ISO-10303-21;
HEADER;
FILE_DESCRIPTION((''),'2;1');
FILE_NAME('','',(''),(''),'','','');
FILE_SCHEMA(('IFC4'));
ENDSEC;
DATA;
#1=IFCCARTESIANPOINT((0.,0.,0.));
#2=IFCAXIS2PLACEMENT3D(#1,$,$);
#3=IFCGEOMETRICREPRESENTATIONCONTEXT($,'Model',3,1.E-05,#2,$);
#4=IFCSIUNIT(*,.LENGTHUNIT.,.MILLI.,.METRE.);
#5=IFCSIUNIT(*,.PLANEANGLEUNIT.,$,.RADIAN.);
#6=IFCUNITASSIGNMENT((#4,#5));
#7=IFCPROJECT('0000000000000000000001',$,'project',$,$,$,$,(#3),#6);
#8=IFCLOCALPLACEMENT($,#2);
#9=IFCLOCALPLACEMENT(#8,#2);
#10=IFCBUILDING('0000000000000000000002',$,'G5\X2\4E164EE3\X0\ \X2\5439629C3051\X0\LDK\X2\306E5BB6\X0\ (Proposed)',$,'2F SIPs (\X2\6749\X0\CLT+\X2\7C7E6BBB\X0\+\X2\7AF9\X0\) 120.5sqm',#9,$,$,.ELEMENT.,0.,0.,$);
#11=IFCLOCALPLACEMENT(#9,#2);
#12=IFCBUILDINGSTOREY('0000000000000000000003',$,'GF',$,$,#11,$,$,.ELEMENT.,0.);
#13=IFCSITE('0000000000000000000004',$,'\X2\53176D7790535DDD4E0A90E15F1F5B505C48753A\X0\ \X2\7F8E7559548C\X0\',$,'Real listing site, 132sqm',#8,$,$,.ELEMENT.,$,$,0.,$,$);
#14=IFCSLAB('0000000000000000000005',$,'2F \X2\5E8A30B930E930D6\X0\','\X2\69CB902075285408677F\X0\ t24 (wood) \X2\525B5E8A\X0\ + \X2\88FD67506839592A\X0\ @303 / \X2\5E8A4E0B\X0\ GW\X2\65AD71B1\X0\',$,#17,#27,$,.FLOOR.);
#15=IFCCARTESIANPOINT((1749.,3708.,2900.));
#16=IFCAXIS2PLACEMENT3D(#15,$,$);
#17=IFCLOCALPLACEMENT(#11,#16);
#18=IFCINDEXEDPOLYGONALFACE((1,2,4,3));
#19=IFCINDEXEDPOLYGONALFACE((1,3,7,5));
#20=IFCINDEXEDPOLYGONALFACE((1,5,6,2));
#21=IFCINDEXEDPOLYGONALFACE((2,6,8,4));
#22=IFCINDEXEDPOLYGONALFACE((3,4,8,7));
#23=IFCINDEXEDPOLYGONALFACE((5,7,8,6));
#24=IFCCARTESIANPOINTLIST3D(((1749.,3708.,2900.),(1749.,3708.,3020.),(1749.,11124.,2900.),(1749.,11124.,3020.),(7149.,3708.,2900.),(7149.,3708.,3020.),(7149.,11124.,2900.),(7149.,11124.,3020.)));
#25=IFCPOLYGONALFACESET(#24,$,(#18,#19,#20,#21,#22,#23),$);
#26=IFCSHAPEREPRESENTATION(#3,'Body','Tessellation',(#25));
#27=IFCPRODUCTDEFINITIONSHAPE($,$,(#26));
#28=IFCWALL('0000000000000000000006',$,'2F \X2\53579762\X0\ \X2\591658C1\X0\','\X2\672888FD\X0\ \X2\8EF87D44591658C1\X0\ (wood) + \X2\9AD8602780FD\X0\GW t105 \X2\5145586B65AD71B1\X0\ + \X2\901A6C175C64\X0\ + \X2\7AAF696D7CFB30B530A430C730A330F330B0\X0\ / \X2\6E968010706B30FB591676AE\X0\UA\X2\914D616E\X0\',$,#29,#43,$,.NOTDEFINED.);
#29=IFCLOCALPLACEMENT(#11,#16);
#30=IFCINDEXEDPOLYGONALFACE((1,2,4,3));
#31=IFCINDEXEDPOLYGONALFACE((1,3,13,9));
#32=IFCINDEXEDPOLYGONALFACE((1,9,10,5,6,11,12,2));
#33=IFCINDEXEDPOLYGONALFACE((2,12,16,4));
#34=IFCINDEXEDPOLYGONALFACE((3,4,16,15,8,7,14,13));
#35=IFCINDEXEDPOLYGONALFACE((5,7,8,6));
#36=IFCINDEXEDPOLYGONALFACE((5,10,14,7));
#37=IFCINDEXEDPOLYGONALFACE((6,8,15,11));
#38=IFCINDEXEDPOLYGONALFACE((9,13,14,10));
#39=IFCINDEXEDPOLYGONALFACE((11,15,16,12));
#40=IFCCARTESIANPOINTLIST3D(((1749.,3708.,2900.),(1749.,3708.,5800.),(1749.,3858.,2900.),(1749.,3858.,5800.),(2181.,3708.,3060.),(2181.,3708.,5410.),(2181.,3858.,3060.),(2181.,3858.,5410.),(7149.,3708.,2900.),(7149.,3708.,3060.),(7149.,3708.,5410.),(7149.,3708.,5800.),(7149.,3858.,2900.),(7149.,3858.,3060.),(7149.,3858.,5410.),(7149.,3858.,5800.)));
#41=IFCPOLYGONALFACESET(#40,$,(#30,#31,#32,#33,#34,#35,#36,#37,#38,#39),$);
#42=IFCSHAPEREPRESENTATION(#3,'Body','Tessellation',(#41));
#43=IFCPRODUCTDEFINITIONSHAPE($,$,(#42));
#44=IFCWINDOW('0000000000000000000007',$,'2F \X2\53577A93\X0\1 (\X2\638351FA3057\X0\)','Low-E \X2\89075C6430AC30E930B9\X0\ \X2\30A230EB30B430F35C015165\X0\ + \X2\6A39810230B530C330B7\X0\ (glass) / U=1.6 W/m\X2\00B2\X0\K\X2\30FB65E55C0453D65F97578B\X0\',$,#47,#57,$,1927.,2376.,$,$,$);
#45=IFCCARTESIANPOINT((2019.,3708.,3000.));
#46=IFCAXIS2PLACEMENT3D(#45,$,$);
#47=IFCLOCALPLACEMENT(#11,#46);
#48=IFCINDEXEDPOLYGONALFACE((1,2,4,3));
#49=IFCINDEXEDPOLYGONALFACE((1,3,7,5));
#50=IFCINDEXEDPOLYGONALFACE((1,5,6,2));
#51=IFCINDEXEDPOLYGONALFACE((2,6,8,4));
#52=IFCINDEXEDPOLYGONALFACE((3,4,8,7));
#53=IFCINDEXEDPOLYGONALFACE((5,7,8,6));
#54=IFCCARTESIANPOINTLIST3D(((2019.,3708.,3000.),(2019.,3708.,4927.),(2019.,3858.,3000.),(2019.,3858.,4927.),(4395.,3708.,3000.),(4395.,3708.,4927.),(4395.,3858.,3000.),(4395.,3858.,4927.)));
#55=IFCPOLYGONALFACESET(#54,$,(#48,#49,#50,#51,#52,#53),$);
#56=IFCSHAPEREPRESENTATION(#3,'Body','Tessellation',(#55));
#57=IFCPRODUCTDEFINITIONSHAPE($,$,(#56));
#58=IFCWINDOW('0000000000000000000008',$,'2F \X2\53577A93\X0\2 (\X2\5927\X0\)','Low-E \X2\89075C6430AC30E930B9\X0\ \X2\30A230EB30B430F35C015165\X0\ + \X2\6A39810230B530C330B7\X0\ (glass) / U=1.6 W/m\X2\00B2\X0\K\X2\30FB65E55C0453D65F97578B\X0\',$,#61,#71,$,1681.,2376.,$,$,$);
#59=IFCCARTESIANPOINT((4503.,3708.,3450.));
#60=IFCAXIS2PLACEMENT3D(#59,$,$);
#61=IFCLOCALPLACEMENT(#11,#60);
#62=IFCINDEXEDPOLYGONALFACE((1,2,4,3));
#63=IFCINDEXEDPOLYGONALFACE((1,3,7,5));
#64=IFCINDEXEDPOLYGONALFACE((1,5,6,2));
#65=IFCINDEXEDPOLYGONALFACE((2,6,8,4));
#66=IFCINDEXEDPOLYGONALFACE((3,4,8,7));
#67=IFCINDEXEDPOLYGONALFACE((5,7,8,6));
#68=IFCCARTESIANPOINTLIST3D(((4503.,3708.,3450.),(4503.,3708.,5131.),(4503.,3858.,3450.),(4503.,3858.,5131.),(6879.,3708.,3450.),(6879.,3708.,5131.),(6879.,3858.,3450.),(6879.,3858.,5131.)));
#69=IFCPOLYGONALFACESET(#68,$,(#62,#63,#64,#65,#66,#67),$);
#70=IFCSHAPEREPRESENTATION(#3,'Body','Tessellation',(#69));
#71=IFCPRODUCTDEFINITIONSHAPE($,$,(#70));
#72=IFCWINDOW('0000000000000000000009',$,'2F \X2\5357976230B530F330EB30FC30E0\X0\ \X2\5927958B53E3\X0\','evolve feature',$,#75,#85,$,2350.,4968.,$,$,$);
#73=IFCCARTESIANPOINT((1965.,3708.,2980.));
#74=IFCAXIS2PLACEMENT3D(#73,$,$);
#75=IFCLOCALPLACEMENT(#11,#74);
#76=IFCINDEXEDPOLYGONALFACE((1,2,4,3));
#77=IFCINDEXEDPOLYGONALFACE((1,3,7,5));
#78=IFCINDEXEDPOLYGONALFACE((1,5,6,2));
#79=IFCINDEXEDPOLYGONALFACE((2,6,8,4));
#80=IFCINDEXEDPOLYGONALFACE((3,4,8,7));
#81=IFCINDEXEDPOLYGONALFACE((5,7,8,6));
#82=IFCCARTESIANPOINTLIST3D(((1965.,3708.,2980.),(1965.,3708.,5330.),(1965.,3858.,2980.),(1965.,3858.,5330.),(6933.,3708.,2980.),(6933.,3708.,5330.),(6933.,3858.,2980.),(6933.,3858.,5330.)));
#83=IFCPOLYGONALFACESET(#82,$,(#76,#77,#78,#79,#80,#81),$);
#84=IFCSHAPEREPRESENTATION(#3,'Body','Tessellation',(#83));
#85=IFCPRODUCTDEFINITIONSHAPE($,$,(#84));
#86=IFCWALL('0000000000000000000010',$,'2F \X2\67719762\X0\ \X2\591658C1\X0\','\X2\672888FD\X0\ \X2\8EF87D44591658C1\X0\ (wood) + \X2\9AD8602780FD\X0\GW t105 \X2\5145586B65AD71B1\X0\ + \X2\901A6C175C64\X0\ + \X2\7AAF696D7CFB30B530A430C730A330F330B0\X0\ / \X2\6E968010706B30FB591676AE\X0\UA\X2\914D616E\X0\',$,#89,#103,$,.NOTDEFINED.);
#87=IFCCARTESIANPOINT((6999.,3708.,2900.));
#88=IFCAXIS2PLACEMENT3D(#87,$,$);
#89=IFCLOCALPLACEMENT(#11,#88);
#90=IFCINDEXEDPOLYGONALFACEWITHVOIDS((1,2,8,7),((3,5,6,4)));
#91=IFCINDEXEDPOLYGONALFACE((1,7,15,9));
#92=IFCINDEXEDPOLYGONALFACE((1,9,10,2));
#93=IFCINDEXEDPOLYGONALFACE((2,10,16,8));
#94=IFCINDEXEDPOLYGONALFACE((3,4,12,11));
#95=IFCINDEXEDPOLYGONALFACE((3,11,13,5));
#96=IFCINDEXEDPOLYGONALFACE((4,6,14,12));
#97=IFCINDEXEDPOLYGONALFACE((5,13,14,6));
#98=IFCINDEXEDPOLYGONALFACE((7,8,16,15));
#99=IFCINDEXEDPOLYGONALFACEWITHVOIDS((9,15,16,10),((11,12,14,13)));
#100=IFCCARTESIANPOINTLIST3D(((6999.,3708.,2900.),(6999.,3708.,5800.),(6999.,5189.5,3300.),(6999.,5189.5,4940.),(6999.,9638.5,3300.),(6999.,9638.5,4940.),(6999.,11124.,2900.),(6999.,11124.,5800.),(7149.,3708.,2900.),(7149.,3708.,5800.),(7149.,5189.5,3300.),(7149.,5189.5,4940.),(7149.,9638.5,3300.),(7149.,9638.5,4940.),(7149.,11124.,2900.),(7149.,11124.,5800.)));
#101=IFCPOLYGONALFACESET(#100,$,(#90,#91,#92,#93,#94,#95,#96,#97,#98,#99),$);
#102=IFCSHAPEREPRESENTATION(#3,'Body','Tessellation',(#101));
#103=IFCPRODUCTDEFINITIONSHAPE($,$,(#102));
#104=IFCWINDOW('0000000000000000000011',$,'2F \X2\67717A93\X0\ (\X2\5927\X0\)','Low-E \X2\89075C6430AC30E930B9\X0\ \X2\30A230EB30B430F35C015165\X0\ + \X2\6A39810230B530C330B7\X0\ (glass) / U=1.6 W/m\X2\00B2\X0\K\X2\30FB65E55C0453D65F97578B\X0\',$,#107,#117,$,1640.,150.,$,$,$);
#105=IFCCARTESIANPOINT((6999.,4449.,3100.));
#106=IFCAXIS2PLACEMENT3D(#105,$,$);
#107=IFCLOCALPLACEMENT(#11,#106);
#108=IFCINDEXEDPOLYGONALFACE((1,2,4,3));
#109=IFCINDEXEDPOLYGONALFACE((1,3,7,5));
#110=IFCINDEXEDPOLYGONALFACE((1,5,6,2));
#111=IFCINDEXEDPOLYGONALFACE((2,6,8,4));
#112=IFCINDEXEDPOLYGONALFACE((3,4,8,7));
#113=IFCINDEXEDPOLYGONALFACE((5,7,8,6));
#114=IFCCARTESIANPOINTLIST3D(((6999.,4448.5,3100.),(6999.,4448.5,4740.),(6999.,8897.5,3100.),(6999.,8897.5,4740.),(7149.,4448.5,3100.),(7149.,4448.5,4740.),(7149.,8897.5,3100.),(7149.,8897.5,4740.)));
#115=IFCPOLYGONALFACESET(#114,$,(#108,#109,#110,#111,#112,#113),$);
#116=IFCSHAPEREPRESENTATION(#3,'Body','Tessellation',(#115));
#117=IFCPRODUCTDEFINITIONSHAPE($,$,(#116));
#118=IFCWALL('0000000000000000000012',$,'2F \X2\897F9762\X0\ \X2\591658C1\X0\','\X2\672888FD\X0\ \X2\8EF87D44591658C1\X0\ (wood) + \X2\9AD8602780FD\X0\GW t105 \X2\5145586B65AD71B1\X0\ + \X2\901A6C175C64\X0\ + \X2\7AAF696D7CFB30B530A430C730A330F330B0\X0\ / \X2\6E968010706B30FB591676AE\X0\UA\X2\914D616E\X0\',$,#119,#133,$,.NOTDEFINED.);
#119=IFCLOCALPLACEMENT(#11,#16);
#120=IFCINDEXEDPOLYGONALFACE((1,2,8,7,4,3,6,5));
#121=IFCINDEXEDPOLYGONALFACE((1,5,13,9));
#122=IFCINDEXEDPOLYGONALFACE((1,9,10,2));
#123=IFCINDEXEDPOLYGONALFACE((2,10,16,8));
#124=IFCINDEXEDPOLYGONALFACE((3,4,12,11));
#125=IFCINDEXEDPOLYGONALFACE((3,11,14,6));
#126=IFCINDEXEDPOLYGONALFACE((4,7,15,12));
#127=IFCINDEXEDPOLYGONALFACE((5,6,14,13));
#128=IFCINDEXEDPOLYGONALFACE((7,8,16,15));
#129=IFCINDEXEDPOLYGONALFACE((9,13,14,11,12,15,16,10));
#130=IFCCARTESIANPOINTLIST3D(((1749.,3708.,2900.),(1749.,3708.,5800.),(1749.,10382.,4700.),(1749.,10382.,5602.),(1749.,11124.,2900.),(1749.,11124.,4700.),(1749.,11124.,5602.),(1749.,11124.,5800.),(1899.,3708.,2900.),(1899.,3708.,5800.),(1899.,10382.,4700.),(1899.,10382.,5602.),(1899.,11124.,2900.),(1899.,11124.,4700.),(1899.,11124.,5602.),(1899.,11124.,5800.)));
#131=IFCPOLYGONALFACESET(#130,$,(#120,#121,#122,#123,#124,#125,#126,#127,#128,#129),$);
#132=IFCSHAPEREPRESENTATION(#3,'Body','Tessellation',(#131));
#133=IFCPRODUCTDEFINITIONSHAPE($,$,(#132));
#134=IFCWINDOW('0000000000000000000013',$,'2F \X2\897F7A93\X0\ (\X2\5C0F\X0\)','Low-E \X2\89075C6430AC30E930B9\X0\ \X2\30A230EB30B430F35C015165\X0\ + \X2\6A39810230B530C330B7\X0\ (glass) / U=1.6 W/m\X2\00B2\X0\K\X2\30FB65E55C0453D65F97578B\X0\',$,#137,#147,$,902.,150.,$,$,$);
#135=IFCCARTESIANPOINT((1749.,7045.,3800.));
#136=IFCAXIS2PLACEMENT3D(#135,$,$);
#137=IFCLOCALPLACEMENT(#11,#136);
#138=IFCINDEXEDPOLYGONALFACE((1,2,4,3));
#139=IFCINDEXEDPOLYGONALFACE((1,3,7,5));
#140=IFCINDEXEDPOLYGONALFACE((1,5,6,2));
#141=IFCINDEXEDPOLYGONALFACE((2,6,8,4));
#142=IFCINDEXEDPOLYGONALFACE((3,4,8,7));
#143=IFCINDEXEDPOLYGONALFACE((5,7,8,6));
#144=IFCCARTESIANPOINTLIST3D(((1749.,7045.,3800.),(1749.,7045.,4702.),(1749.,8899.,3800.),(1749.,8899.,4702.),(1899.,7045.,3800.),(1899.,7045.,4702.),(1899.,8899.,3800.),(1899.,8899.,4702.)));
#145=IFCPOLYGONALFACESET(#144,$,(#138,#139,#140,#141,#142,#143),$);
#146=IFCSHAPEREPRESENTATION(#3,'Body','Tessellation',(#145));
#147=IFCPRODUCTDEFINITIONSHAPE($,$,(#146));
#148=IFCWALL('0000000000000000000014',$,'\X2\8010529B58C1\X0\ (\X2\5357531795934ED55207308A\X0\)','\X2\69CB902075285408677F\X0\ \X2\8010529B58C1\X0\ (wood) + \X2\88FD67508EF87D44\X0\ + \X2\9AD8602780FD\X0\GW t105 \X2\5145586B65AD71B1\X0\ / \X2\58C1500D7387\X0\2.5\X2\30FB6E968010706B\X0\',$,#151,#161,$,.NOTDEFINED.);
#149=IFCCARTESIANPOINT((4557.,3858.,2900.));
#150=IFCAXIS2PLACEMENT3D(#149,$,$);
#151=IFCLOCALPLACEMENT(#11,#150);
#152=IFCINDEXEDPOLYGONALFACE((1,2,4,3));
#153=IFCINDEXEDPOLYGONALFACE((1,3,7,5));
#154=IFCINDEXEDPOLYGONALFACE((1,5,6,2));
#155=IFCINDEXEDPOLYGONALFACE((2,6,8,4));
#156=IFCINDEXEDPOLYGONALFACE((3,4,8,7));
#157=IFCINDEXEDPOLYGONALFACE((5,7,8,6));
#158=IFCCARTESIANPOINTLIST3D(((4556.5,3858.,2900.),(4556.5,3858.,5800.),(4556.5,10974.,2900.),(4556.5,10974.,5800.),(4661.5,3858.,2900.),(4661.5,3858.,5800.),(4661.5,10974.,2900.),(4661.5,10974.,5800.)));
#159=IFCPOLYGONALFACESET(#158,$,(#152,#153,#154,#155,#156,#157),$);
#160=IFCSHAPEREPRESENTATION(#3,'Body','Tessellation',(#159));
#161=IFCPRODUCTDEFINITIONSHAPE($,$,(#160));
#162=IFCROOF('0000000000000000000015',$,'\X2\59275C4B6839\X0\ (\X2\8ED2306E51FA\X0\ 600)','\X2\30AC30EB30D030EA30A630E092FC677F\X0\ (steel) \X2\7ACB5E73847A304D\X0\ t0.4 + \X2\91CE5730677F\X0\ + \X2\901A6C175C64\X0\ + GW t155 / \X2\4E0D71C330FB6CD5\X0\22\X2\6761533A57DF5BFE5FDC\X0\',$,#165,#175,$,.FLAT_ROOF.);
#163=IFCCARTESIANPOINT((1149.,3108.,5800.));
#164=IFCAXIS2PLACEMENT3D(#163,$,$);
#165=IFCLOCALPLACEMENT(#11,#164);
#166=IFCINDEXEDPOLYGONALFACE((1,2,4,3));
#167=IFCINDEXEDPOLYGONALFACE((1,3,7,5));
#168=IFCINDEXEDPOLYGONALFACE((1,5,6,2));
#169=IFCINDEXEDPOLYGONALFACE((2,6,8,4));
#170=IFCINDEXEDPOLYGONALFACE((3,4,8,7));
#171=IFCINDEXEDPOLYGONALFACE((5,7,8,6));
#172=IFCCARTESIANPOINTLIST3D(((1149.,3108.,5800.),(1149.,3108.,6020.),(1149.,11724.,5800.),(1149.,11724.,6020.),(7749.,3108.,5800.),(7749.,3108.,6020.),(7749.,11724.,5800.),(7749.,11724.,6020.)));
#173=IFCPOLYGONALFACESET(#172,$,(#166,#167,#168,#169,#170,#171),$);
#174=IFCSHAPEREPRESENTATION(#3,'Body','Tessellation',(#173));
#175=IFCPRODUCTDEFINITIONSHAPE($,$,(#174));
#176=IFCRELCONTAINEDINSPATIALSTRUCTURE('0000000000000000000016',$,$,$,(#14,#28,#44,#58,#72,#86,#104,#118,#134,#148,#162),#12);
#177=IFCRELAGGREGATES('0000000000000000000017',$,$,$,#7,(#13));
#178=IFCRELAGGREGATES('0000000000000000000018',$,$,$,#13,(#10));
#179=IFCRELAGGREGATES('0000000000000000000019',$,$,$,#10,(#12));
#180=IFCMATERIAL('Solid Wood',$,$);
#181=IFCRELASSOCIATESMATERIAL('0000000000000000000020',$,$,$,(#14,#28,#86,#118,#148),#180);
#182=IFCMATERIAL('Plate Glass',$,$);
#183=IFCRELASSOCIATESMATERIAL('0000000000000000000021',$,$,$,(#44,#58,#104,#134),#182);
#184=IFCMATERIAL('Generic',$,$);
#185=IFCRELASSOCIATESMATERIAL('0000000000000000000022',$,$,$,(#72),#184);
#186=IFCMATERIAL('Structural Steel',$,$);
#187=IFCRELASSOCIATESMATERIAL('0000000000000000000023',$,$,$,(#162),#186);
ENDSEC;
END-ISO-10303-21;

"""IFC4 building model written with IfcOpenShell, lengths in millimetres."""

from ifc_helpers import new_model, si_unit, frame, frame_2d, origin, place, context, project, spatial, rectangle, extrude, material, element, fill, save


model = new_model("IFC4")

# Units and contexts
model_context = context("Model", 3, precision=1e-05, world=origin())
ifc_project = project(units=[si_unit("LENGTHUNIT", "METRE", prefix="MILLI"), si_unit("PLANEANGLEUNIT", "RADIAN")], contexts=[model_context])

# Site, building, storey
site_placement = place(None, origin())
site = spatial("IfcSite", under=ifc_project, at=site_placement, Name="北海道川上郡弟子屈町 美留和", ObjectType="Real listing site, 132sqm", CompositionType="ELEMENT", RefElevation=0.0)
building_placement = place(site_placement, origin())
building = spatial("IfcBuilding", under=site, at=building_placement, Name="G5世代 吹抜けLDKの家 (Proposed)", ObjectType="2F SIPs (杉CLT+籾殻+竹) 120.5sqm", CompositionType="ELEMENT", ElevationOfRefHeight=0.0, ElevationOfTerrain=0.0)
storey_placement = place(building_placement, origin())
storey = spatial("IfcBuildingStorey", under=building, at=storey_placement, Name="GF", CompositionType="ELEMENT", Elevation=0.0)

# Slab
ifc_material_1 = material(Name="Solid Wood")
slab_placement = place(storey_placement, frame((1749.0, 3708.0, 2900.0)))
element("IfcSlab", 1, at=slab_placement, inside=storey, material=ifc_material_1, Name="2F 床スラブ", Description="構造用合板 t24 (wood) 剛床 + 製材根太 @303 / 床下 GW断熱", PredefinedType="FLOOR", context=model_context, shape_type="SweptSolid", body=[
    extrude(rectangle(XDim=5400.0, YDim=7416.0, at=frame_2d((2700.0, 3708.0))), frame((1749.0, 3708.0, 2900.0)), (0.0, 0.0, 1.0), 120.0),
])

# Wall, openings, windows
wall_1_placement = place(storey_placement, frame((1749.0, 3708.0, 2900.0)))
wall_1 = element("IfcWall", 2, at=wall_1_placement, inside=storey, material=ifc_material_1, Name="2F 南面 外壁", Description="木製 軸組外壁 (wood) + 高性能GW t105 充填断熱 + 通気層 + 窯業系サイディング / 準耐火・外皮UA配慮", PredefinedType="NOTDEFINED", context=model_context, shape_type="SweptSolid", body=[
    extrude(rectangle(XDim=5400.0, YDim=150.0, at=frame_2d((2700.0, 75.0))), frame((1749.0, 3708.0, 2900.0)), (0.0, 0.0, 1.0), 2900.0),
])
opening_1_placement = place(storey_placement, frame((2019.0, 3708.0, 3000.0)))
opening_1 = element("IfcOpeningElement", 3, at=opening_1_placement, cuts=wall_1, PredefinedType="NOTDEFINED", context=model_context, shape_type="SweptSolid", body=[
    extrude(rectangle(XDim=2376.0, YDim=150.0, at=frame_2d((1188.0, 75.0))), frame((2019.0, 3708.0, 3000.0)), (0.0, 0.0, 1.0), 1927.0),
])
opening_2_placement = place(storey_placement, frame((4503.0, 3708.0, 3450.0)))
opening_2 = element("IfcOpeningElement", 4, at=opening_2_placement, cuts=wall_1, PredefinedType="NOTDEFINED", context=model_context, shape_type="SweptSolid", body=[
    extrude(rectangle(XDim=2376.0, YDim=150.0, at=frame_2d((1188.0, 75.0))), frame((4503.0, 3708.0, 3450.0)), (0.0, 0.0, 1.0), 1681.0),
])
opening_3_placement = place(storey_placement, frame((1965.0, 3708.0, 2980.0)))
opening_3 = element("IfcOpeningElement", 5, at=opening_3_placement, cuts=wall_1, PredefinedType="NOTDEFINED", context=model_context, shape_type="SweptSolid", body=[
    extrude(rectangle(XDim=4968.0, YDim=150.0, at=frame_2d((2484.0, 75.0))), frame((1965.0, 3708.0, 2980.0)), (0.0, 0.0, 1.0), 2350.0),
])
ifc_material_2 = material(Name="Plate Glass")
window_1_placement = place(storey_placement, frame((2019.0, 3708.0, 3000.0)))
window_1 = element("IfcWindow", 6, at=window_1_placement, inside=storey, material=ifc_material_2, Name="2F 南窓1 (掃出し)", Description="Low-E 複層ガラス アルゴン封入 + 樹脂サッシ (glass) / U=1.6 W/m²K・日射取得型", OverallHeight=1927.0, OverallWidth=2376.0, context=model_context, shape_type="SweptSolid", body=[
    extrude(rectangle(XDim=2376.0, YDim=150.0, at=frame_2d((1188.0, 75.0))), frame((2019.0, 3708.0, 3000.0)), (0.0, 0.0, 1.0), 1927.0),
])
fill(opening_1, window_1)
window_2_placement = place(storey_placement, frame((4503.0, 3708.0, 3450.0)))
window_2 = element("IfcWindow", 7, at=window_2_placement, inside=storey, material=ifc_material_2, Name="2F 南窓2 (大)", Description="Low-E 複層ガラス アルゴン封入 + 樹脂サッシ (glass) / U=1.6 W/m²K・日射取得型", OverallHeight=1681.0, OverallWidth=2376.0, context=model_context, shape_type="SweptSolid", body=[
    extrude(rectangle(XDim=2376.0, YDim=150.0, at=frame_2d((1188.0, 75.0))), frame((4503.0, 3708.0, 3450.0)), (0.0, 0.0, 1.0), 1681.0),
])
fill(opening_2, window_2)
ifc_material_3 = material(Name="Generic")
window_3_placement = place(storey_placement, frame((1965.0, 3708.0, 2980.0)))
window_3 = element("IfcWindow", 8, at=window_3_placement, inside=storey, material=ifc_material_3, Name="2F 南面サンルーム 大開口", Description="evolve feature", OverallHeight=2350.0, OverallWidth=4968.0, context=model_context, shape_type="SweptSolid", body=[
    extrude(rectangle(XDim=4968.0, YDim=150.0, at=frame_2d((2484.0, 75.0))), frame((1965.0, 3708.0, 2980.0)), (0.0, 0.0, 1.0), 2350.0),
])
fill(opening_3, window_3)

# Walls, openings, windows
wall_2_placement = place(storey_placement, frame((6999.0, 3708.0, 2900.0)))
wall_2 = element("IfcWall", 9, at=wall_2_placement, inside=storey, material=ifc_material_1, Name="2F 東面 外壁", Description="木製 軸組外壁 (wood) + 高性能GW t105 充填断熱 + 通気層 + 窯業系サイディング / 準耐火・外皮UA配慮", PredefinedType="NOTDEFINED", context=model_context, shape_type="SweptSolid", body=[
    extrude(rectangle(XDim=150.0, YDim=7416.0, at=frame_2d((75.0, 3708.0))), frame((6999.0, 3708.0, 2900.0)), (0.0, 0.0, 1.0), 2900.0),
])
opening_4_placement = place(storey_placement, frame((6999.0, 4449.0, 3100.0)))
opening_4 = element("IfcOpeningElement", 10, at=opening_4_placement, cuts=wall_2, PredefinedType="NOTDEFINED", context=model_context, shape_type="SweptSolid", body=[
    extrude(rectangle(XDim=150.0, YDim=4449.0, at=frame_2d((75.0, 2224.0))), frame((6999.0, 4449.0, 3100.0)), (0.0, 0.0, 1.0), 1640.0),
])
window_4_placement = place(storey_placement, frame((6999.0, 4449.0, 3100.0)))
window_4 = element("IfcWindow", 11, at=window_4_placement, inside=storey, material=ifc_material_2, Name="2F 東窓 (大)", Description="Low-E 複層ガラス アルゴン封入 + 樹脂サッシ (glass) / U=1.6 W/m²K・日射取得型", OverallHeight=1640.0, OverallWidth=150.0, context=model_context, shape_type="SweptSolid", body=[
    extrude(rectangle(XDim=150.0, YDim=4449.0, at=frame_2d((75.0, 2224.0))), frame((6999.0, 4449.0, 3100.0)), (0.0, 0.0, 1.0), 1640.0),
])
fill(opening_4, window_4)
wall_3_placement = place(storey_placement, frame((1749.0, 3708.0, 2900.0)))
wall_3 = element("IfcWall", 12, at=wall_3_placement, inside=storey, material=ifc_material_1, Name="2F 西面 外壁", Description="木製 軸組外壁 (wood) + 高性能GW t105 充填断熱 + 通気層 + 窯業系サイディング / 準耐火・外皮UA配慮", PredefinedType="NOTDEFINED", context=model_context, shape_type="SweptSolid", body=[
    extrude(rectangle(XDim=150.0, YDim=7416.0, at=frame_2d((75.0, 3708.0))), frame((1749.0, 3708.0, 2900.0)), (0.0, 0.0, 1.0), 2900.0),
])
opening_5_placement = place(storey_placement, frame((1749.0, 7045.0, 3800.0)))
opening_5 = element("IfcOpeningElement", 13, at=opening_5_placement, cuts=wall_3, PredefinedType="NOTDEFINED", context=model_context, shape_type="SweptSolid", body=[
    extrude(rectangle(XDim=150.0, YDim=1854.0, at=frame_2d((75.0, 927.0))), frame((1749.0, 7045.0, 3800.0)), (0.0, 0.0, 1.0), 902.0),
])
window_5_placement = place(storey_placement, frame((1749.0, 7045.0, 3800.0)))
window_5 = element("IfcWindow", 14, at=window_5_placement, inside=storey, material=ifc_material_2, Name="2F 西窓 (小)", Description="Low-E 複層ガラス アルゴン封入 + 樹脂サッシ (glass) / U=1.6 W/m²K・日射取得型", OverallHeight=902.0, OverallWidth=150.0, context=model_context, shape_type="SweptSolid", body=[
    extrude(rectangle(XDim=150.0, YDim=1854.0, at=frame_2d((75.0, 927.0))), frame((1749.0, 7045.0, 3800.0)), (0.0, 0.0, 1.0), 902.0),
])
fill(opening_5, window_5)

# Wall
wall_4_placement = place(storey_placement, frame((4557.0, 3858.0, 2900.0)))
element("IfcWall", 15, at=wall_4_placement, inside=storey, material=ifc_material_1, Name="耐力壁 (南北間仕切り)", Description="構造用合板 耐力壁 (wood) + 製材軸組 + 高性能GW t105 充填断熱 / 壁倍率2.5・準耐火", PredefinedType="NOTDEFINED", context=model_context, shape_type="SweptSolid", body=[
    extrude(rectangle(XDim=105.0, YDim=7116.0, at=frame_2d((52.0, 3558.0))), frame((4557.0, 3858.0, 2900.0)), (0.0, 0.0, 1.0), 2900.0),
])

# Roof
ifc_material_4 = material(Name="Structural Steel")
roof_1_placement = place(storey_placement, frame((1149.0, 3108.0, 5800.0)))
element("IfcRoof", 16, at=roof_1_placement, inside=storey, material=ifc_material_4, Name="大屋根 (軒の出 600)", Description="ガルバリウム鋼板 (steel) 立平葺き t0.4 + 野地板 + 通気層 + GW t155 / 不燃・法22条区域対応", PredefinedType="FLAT_ROOF", context=model_context, shape_type="SweptSolid", body=[
    extrude(rectangle(XDim=6600.0, YDim=8616.0, at=frame_2d((3300.0, 4308.0))), frame((1149.0, 3108.0, 5800.0)), (0.0, 0.0, 1.0), 220.0),
])

save(model, "model.ifc")
